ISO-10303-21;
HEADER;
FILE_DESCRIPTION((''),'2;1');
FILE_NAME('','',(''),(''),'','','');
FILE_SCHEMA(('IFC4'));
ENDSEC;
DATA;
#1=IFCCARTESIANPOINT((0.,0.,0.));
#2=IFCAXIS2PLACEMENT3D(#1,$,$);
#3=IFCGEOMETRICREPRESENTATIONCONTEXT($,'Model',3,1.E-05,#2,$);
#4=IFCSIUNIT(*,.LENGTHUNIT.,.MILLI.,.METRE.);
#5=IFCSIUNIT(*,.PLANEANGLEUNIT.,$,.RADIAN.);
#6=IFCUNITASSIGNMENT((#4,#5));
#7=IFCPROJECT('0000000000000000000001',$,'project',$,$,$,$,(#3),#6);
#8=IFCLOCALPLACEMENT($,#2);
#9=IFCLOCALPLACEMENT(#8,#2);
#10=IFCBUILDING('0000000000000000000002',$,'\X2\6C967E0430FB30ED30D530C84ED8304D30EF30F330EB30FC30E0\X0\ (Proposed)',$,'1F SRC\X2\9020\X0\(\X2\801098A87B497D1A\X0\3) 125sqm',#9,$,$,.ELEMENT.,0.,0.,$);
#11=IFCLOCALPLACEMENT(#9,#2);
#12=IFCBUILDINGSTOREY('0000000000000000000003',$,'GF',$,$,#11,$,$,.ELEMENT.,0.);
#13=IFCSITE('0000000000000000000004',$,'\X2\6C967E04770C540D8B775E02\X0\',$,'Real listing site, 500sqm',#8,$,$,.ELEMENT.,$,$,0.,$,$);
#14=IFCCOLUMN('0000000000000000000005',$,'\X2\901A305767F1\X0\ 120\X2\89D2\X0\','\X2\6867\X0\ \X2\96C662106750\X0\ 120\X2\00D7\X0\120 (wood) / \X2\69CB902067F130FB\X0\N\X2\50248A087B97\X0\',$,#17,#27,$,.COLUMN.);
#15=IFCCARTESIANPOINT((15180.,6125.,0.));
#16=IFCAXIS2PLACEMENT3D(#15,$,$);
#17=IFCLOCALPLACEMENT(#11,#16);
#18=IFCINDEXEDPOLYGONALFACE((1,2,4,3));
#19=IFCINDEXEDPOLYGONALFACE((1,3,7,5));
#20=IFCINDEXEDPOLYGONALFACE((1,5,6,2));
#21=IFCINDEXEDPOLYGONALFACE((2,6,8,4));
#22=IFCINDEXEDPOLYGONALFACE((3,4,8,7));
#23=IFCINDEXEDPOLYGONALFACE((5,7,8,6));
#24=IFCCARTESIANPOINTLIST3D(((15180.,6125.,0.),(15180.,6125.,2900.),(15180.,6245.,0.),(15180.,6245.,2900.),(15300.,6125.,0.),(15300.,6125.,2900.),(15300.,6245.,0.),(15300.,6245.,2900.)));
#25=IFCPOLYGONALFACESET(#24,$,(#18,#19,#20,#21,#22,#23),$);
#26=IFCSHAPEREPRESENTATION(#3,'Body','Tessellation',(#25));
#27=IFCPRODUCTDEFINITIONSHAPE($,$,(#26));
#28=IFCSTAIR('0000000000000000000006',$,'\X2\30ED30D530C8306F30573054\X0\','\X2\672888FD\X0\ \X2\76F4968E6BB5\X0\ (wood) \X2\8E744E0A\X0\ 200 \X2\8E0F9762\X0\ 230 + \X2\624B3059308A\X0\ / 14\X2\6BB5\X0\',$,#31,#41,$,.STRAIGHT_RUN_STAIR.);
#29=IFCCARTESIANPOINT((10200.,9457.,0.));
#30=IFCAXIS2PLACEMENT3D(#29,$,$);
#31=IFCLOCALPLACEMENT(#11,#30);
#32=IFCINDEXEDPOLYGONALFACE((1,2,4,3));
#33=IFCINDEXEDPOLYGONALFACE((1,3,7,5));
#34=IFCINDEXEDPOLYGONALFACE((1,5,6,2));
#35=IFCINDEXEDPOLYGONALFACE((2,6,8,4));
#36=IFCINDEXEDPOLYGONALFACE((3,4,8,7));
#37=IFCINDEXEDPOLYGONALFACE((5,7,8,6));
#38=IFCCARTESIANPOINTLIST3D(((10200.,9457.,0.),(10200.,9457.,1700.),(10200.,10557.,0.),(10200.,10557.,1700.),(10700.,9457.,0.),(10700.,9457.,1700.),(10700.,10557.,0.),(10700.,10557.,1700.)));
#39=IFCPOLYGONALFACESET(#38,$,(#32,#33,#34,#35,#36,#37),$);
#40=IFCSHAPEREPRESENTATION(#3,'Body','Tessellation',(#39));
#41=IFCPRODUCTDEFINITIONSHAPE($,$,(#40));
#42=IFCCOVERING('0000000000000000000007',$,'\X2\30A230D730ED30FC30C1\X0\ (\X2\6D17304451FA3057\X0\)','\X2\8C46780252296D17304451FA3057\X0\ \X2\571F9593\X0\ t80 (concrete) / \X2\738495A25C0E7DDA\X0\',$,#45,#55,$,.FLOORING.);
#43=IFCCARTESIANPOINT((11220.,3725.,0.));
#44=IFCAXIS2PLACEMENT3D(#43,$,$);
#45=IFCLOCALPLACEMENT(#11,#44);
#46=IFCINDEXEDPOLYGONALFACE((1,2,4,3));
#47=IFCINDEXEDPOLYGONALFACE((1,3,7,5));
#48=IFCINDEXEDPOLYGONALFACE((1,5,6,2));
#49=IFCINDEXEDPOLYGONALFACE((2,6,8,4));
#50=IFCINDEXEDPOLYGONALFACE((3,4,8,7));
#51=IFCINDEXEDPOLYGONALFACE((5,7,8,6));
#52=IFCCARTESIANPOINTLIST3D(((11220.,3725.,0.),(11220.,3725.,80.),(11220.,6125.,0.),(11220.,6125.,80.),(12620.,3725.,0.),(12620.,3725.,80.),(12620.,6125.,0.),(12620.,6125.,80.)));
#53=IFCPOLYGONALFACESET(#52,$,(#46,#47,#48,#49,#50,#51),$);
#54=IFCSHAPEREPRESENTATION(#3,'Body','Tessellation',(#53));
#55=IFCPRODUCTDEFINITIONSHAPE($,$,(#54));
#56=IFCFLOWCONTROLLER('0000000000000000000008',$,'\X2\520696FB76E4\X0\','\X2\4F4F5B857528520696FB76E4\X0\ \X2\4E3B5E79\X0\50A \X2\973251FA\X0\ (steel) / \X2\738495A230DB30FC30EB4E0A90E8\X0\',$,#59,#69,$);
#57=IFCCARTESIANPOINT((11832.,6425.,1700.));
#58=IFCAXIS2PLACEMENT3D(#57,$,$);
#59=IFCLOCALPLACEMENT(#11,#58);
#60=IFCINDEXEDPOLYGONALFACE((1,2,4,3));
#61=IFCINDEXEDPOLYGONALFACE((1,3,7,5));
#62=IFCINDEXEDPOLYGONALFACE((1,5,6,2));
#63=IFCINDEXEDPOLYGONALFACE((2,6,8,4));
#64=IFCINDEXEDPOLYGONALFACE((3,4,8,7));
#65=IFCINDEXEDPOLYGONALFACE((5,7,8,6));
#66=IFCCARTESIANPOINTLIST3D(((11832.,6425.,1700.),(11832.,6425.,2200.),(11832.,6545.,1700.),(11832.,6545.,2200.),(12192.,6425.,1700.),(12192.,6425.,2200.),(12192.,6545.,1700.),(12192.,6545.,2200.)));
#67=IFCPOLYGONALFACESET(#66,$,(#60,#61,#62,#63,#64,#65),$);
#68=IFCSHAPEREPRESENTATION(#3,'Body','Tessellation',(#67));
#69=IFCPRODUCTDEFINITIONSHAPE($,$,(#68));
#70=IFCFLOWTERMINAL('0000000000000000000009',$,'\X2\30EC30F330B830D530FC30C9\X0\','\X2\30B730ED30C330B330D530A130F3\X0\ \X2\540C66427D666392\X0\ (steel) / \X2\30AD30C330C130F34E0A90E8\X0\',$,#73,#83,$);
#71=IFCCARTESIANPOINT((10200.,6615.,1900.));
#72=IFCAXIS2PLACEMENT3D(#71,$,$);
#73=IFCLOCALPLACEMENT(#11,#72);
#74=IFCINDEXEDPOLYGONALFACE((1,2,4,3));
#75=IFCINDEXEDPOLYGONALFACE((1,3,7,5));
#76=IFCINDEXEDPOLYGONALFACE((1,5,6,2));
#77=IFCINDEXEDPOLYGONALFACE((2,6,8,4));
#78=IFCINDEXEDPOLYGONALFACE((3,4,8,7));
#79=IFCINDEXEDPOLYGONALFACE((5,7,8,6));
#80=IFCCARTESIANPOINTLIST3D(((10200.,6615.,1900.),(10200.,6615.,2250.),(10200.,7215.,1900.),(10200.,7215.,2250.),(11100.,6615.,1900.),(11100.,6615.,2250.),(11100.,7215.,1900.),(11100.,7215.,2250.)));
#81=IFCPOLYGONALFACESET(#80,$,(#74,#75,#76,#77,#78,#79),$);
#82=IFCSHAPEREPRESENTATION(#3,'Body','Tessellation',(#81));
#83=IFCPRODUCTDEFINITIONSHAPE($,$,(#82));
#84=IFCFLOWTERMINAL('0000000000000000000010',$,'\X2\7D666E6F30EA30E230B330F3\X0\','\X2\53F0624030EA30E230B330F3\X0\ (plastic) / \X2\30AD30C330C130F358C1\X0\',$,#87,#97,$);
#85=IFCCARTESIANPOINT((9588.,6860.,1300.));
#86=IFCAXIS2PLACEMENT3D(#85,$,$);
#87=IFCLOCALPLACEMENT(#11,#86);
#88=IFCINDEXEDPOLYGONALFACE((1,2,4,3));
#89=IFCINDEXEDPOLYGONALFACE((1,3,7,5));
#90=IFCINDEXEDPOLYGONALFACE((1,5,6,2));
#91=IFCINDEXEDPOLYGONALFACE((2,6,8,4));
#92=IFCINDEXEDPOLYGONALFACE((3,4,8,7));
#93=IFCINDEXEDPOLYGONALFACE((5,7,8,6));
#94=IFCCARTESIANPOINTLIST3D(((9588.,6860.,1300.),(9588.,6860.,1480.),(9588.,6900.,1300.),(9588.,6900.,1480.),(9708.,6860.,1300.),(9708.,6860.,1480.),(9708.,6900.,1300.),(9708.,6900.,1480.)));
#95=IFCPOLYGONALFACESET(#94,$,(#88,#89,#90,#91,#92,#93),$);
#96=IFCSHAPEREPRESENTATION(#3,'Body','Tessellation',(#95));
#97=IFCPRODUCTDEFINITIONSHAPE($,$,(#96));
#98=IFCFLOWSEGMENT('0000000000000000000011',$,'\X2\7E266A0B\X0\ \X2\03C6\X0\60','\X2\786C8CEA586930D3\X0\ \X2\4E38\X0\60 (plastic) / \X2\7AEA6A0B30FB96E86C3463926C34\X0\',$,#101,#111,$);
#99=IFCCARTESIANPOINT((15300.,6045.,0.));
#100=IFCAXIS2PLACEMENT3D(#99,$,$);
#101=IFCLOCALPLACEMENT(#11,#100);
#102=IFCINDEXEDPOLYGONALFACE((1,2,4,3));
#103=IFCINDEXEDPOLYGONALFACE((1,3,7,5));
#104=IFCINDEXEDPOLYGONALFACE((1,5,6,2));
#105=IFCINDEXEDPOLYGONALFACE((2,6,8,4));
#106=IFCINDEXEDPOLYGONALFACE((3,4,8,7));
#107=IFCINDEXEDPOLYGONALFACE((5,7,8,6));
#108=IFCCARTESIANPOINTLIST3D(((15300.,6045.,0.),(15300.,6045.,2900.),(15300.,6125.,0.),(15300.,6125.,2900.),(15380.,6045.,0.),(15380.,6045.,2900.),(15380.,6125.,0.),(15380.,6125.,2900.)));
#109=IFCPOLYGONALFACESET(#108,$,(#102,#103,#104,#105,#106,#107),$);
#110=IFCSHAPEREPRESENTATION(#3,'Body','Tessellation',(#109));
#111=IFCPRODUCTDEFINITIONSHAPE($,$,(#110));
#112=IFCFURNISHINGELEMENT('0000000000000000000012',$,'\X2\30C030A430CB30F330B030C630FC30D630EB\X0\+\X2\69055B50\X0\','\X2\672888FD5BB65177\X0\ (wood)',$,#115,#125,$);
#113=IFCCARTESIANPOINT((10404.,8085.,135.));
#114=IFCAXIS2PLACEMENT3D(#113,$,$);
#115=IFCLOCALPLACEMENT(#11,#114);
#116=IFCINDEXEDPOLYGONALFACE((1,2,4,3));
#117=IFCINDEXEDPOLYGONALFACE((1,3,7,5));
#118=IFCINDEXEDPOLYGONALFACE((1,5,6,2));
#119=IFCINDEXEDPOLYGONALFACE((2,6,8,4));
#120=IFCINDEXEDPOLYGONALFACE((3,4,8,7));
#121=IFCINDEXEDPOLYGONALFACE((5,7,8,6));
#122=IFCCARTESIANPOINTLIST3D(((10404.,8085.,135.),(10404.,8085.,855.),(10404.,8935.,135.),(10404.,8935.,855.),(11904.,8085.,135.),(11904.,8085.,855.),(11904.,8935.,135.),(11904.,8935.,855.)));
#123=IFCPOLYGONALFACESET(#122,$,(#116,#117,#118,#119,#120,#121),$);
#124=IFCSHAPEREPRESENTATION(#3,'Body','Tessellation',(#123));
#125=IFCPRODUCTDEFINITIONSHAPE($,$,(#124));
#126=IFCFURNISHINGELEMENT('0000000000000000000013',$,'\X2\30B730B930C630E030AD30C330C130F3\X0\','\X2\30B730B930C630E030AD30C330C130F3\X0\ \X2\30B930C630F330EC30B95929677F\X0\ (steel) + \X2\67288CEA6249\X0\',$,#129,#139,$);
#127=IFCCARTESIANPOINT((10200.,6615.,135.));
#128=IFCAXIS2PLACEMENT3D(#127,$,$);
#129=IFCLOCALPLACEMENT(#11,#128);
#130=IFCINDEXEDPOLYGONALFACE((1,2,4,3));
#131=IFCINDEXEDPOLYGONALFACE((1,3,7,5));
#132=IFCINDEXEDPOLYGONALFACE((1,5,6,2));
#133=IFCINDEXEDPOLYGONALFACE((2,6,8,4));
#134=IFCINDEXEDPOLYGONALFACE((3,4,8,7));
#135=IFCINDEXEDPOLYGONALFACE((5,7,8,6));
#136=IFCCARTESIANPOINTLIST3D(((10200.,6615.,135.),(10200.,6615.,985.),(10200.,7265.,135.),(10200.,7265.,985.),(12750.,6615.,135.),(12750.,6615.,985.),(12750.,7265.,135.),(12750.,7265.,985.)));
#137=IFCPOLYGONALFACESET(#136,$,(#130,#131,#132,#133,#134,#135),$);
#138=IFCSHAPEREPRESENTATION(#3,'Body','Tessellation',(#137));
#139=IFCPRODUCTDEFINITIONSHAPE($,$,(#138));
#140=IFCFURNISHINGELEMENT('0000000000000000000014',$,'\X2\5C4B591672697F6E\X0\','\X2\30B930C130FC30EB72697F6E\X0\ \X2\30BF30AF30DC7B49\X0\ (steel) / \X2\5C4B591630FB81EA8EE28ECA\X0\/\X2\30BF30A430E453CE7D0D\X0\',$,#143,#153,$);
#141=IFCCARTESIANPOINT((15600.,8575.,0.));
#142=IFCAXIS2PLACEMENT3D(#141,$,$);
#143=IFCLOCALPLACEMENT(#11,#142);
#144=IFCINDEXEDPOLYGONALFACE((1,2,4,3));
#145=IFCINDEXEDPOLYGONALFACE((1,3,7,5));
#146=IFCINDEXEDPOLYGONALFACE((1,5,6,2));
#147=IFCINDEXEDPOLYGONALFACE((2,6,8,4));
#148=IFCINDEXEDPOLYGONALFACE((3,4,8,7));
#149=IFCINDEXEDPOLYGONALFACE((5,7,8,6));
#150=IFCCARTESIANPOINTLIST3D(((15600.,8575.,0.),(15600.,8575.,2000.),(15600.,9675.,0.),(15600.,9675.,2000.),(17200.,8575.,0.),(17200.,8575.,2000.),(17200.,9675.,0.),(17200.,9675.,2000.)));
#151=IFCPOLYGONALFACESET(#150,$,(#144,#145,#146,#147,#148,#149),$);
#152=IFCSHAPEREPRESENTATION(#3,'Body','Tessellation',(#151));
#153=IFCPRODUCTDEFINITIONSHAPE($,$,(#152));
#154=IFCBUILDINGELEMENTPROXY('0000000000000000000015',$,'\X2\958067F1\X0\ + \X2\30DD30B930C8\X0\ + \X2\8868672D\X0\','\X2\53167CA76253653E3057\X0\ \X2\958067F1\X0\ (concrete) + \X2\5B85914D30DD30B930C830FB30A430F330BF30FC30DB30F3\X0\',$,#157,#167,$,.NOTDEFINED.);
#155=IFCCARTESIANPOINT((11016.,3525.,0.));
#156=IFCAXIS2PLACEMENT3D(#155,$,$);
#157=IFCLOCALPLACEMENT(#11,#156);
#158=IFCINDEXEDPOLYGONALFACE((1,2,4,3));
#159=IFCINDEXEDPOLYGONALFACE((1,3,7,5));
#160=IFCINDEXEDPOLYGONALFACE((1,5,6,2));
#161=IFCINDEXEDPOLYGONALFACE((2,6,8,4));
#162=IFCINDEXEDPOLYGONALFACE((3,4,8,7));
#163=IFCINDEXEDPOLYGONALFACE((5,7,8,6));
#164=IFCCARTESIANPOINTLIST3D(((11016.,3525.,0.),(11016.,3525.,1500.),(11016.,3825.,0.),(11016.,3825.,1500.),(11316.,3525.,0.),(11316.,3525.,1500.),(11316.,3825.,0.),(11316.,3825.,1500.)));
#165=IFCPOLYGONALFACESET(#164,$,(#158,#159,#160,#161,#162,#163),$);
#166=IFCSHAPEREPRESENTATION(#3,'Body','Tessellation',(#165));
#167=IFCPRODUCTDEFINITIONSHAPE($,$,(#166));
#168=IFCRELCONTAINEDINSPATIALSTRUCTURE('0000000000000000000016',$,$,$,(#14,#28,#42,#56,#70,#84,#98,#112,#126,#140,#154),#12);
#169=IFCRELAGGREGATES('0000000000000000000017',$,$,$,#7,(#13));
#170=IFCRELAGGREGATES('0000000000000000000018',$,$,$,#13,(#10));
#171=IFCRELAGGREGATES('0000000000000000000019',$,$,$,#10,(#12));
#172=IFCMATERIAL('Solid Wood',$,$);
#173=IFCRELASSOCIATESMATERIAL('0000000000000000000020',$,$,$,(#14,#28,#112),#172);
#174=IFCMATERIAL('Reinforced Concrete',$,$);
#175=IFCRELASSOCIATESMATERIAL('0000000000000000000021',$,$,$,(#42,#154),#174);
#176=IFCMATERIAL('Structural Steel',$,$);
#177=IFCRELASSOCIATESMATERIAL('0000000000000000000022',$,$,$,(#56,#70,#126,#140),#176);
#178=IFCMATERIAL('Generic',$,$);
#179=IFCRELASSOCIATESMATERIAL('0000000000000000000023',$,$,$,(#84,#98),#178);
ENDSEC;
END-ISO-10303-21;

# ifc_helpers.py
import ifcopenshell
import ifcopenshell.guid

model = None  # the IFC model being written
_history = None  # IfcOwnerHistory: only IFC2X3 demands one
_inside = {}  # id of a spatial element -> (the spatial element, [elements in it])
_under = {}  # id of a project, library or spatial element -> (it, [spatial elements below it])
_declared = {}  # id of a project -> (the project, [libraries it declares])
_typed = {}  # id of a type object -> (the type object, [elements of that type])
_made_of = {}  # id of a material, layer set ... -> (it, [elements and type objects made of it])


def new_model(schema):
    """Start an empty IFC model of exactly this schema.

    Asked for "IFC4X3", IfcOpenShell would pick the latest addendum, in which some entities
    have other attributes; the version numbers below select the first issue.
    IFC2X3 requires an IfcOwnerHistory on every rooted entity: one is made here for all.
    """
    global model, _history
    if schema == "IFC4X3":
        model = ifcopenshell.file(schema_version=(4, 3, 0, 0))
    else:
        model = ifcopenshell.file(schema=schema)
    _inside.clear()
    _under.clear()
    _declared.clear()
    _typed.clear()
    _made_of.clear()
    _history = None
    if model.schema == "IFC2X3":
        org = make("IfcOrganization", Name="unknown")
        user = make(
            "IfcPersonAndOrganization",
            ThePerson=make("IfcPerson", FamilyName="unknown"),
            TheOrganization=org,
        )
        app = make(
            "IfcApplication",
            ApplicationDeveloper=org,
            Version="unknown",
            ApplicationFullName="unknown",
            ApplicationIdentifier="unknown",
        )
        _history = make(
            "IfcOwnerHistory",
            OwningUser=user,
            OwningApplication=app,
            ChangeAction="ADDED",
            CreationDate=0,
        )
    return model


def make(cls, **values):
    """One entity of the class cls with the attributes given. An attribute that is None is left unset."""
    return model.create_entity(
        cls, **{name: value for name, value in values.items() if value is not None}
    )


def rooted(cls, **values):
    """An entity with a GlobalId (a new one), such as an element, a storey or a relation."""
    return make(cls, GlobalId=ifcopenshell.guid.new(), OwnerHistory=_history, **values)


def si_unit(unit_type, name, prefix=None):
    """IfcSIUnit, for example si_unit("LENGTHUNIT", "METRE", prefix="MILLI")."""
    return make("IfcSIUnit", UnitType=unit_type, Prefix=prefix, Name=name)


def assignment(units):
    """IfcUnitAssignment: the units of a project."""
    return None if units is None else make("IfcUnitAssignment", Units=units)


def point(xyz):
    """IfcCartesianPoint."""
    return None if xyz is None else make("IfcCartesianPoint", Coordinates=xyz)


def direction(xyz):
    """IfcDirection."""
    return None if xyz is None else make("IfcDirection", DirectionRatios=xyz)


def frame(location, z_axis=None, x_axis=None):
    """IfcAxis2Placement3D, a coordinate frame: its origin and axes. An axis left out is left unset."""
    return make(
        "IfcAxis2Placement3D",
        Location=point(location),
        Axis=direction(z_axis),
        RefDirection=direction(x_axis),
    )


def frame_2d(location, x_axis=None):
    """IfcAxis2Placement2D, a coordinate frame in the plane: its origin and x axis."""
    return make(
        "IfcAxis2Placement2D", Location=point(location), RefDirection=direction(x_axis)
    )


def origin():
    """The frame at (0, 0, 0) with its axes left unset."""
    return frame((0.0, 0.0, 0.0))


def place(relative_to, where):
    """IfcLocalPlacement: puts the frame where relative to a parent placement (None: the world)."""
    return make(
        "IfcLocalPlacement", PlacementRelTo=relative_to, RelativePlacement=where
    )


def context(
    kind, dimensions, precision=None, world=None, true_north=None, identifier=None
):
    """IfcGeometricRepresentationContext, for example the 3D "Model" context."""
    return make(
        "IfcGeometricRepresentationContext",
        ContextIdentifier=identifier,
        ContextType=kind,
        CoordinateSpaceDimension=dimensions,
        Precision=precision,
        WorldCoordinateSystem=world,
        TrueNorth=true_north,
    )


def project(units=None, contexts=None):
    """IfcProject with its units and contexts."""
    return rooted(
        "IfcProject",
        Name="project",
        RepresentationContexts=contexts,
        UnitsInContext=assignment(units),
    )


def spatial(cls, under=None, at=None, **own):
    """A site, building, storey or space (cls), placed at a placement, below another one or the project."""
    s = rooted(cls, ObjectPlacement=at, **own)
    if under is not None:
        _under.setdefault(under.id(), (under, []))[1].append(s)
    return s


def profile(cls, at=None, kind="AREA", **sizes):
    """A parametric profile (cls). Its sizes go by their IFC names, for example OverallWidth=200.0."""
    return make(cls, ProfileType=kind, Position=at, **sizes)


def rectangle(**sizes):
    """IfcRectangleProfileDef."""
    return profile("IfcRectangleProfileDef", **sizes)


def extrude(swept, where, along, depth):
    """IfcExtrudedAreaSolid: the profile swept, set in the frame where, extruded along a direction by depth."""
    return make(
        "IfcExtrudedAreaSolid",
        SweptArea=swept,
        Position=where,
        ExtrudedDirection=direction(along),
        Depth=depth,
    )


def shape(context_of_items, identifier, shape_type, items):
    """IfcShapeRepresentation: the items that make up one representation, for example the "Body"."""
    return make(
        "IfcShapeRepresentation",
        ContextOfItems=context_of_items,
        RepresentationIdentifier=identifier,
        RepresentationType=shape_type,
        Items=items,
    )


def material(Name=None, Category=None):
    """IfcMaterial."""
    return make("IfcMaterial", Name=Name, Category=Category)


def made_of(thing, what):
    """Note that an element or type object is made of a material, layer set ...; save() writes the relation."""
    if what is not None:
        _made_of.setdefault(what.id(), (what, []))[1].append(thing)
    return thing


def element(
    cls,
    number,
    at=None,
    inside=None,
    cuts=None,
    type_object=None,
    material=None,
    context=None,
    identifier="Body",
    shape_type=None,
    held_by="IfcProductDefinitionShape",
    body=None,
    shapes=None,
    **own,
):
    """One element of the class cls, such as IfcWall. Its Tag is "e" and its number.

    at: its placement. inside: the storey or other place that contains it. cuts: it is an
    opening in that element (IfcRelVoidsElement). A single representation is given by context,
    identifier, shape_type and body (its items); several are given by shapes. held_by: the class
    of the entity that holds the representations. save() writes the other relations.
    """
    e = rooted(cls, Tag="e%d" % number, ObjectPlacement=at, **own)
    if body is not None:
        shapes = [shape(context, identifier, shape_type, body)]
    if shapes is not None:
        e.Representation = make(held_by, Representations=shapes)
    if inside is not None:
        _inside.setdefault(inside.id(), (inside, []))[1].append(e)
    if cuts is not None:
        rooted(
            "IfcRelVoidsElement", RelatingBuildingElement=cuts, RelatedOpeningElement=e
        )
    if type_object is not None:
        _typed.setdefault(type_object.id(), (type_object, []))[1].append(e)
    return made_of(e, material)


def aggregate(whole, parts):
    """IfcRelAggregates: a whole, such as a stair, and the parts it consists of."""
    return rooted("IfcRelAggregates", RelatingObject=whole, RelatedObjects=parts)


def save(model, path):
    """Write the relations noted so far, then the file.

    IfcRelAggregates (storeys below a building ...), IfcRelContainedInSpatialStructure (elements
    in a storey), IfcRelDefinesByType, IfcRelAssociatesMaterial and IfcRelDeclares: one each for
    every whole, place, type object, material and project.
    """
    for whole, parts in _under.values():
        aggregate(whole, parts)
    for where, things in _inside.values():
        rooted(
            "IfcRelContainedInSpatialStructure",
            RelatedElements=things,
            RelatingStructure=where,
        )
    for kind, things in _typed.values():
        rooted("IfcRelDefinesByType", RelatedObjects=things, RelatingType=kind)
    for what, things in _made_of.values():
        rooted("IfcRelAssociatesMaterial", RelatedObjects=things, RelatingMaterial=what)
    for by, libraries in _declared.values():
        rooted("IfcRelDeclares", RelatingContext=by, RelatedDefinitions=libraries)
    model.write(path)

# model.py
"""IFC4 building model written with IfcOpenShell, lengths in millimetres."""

from ifc_helpers import new_model, si_unit, frame, frame_2d, origin, place, context, project, spatial, rectangle, extrude, material, element, save


model = new_model("IFC4")

# Units and contexts
model_context = context("Model", 3, precision=1e-05, world=origin())
ifc_project = project(units=[si_unit("LENGTHUNIT", "METRE", prefix="MILLI"), si_unit("PLANEANGLEUNIT", "RADIAN")], contexts=[model_context])

# Site, building, storey
site_placement = place(None, origin())
site = spatial("IfcSite", under=ifc_project, at=site_placement, Name="沖縄県名護市", ObjectType="Real listing site, 500sqm", CompositionType="ELEMENT", RefElevation=0.0)
building_placement = place(site_placement, origin())
building = spatial("IfcBuilding", under=site, at=building_placement, Name="沖縄・ロフト付きワンルーム (Proposed)", ObjectType="1F SRC造(耐風等級3) 125sqm", CompositionType="ELEMENT", ElevationOfRefHeight=0.0, ElevationOfTerrain=0.0)
storey_placement = place(building_placement, origin())
storey = spatial("IfcBuildingStorey", under=building, at=storey_placement, Name="GF", CompositionType="ELEMENT", Elevation=0.0)

# Column
ifc_material_1 = material(Name="Solid Wood")
column_1_placement = place(storey_placement, frame((15180.0, 6125.0, 0.0)))
element("IfcColumn", 1, at=column_1_placement, inside=storey, material=ifc_material_1, Name="通し柱 120角", Description="桧 集成材 120×120 (wood) / 構造柱・N値計算", PredefinedType="COLUMN", context=model_context, shape_type="SweptSolid", body=[
    extrude(rectangle(XDim=120.0, YDim=120.0, at=frame_2d((60.0, 60.0))), frame((15180.0, 6125.0, 0.0)), (0.0, 0.0, 1.0), 2900.0),
])

# Stair
stair_placement = place(storey_placement, frame((10200.0, 9457.0, 0.0)))
element("IfcStair", 2, at=stair_placement, inside=storey, material=ifc_material_1, Name="ロフトはしご", Description="木製 直階段 (wood) 蹴上 200 踏面 230 + 手すり / 14段", PredefinedType="STRAIGHT_RUN_STAIR", context=model_context, shape_type="SweptSolid", body=[
    extrude(rectangle(XDim=500.0, YDim=1100.0, at=frame_2d((250.0, 550.0))), frame((10200.0, 9457.0, 0.0)), (0.0, 0.0, 1.0), 1700.0),
])

# Covering
ifc_material_2 = material(Name="Reinforced Concrete")
covering_placement = place(storey_placement, frame((11220.0, 3725.0, 0.0)))
element("IfcCovering", 3, at=covering_placement, inside=storey, material=ifc_material_2, Name="アプローチ (洗い出し)", Description="豆砂利洗い出し 土間 t80 (concrete) / 玄関導線", PredefinedType="FLOORING", context=model_context, shape_type="SweptSolid", body=[
    extrude(rectangle(XDim=1400.0, YDim=2400.0, at=frame_2d((700.0, 1200.0))), frame((11220.0, 3725.0, 0.0)), (0.0, 0.0, 1.0), 80.0),
])

# Flow controller
ifc_material_3 = material(Name="Structural Steel")
flow_controller_placement = place(storey_placement, frame((11832.0, 6425.0, 1700.0)))
element("IfcFlowController", 4, at=flow_controller_placement, inside=storey, material=ifc_material_3, Name="分電盤", Description="住宅用分電盤 主幹50A 露出 (steel) / 玄関ホール上部", context=model_context, shape_type="SweptSolid", body=[
    extrude(rectangle(XDim=360.0, YDim=120.0, at=frame_2d((180.0, 60.0))), frame((11832.0, 6425.0, 1700.0)), (0.0, 0.0, 1.0), 500.0),
])

# Flow terminals
flow_terminal_1_placement = place(storey_placement, frame((10200.0, 6615.0, 1900.0)))
element("IfcFlowTerminal", 5, at=flow_terminal_1_placement, inside=storey, material=ifc_material_3, Name="レンジフード", Description="シロッコファン 同時給排 (steel) / キッチン上部", context=model_context, shape_type="SweptSolid", body=[
    extrude(rectangle(XDim=900.0, YDim=600.0, at=frame_2d((450.0, 300.0))), frame((10200.0, 6615.0, 1900.0)), (0.0, 0.0, 1.0), 350.0),
])
ifc_material_4 = material(Name="Generic")
flow_terminal_2_placement = place(storey_placement, frame((9588.0, 6860.0, 1300.0)))
element("IfcFlowTerminal", 6, at=flow_terminal_2_placement, inside=storey, material=ifc_material_4, Name="給湯リモコン", Description="台所リモコン (plastic) / キッチン壁", context=model_context, shape_type="SweptSolid", body=[
    extrude(rectangle(XDim=120.0, YDim=40.0, at=frame_2d((60.0, 20.0))), frame((9588.0, 6860.0, 1300.0)), (0.0, 0.0, 1.0), 180.0),
])

# Flow segment
flow_segment_placement = place(storey_placement, frame((15300.0, 6045.0, 0.0)))
element("IfcFlowSegment", 7, at=flow_segment_placement, inside=storey, material=ifc_material_4, Name="縦樋 φ60", Description="硬質塩ビ 丸60 (plastic) / 竪樋・雨水排水", context=model_context, shape_type="SweptSolid", body=[
    extrude(rectangle(XDim=80.0, YDim=80.0, at=frame_2d((40.0, 40.0))), frame((15300.0, 6045.0, 0.0)), (0.0, 0.0, 1.0), 2900.0),
])

# Furnishing elements
furnishing_1_placement = place(storey_placement, frame((10404.0, 8085.0, 135.0)))
element("IfcFurnishingElement", 8, at=furnishing_1_placement, inside=storey, material=ifc_material_1, Name="ダイニングテーブル+椅子", Description="木製家具 (wood)", context=model_context, shape_type="SweptSolid", body=[
    extrude(rectangle(XDim=1500.0, YDim=850.0, at=frame_2d((750.0, 425.0))), frame((10404.0, 8085.0, 135.0)), (0.0, 0.0, 1.0), 720.0),
])
furnishing_2_placement = place(storey_placement, frame((10200.0, 6615.0, 135.0)))
element("IfcFurnishingElement", 9, at=furnishing_2_placement, inside=storey, material=ifc_material_3, Name="システムキッチン", Description="システムキッチン ステンレス天板 (steel) + 木質扉", context=model_context, shape_type="SweptSolid", body=[
    extrude(rectangle(XDim=2550.0, YDim=650.0, at=frame_2d((1275.0, 325.0))), frame((10200.0, 6615.0, 135.0)), (0.0, 0.0, 1.0), 850.0),
])
furnishing_3_placement = place(storey_placement, frame((15600.0, 8575.0, 0.0)))
element("IfcFurnishingElement", 10, at=furnishing_3_placement, inside=storey, material=ifc_material_3, Name="屋外物置", Description="スチール物置 タクボ等 (steel) / 屋外・自転車/タイヤ収納", context=model_context, shape_type="SweptSolid", body=[
    extrude(rectangle(XDim=1600.0, YDim=1100.0, at=frame_2d((800.0, 550.0))), frame((15600.0, 8575.0, 0.0)), (0.0, 0.0, 1.0), 2000.0),
])

# Building element proxy
proxy_placement = place(storey_placement, frame((11016.0, 3525.0, 0.0)))
element("IfcBuildingElementProxy", 11, at=proxy_placement, inside=storey, material=ifc_material_2, Name="門柱 + ポスト + 表札", Description="化粧打放し 門柱 (concrete) + 宅配ポスト・インターホン", PredefinedType="NOTDEFINED", context=model_context, shape_type="SweptSolid", body=[
    extrude(rectangle(XDim=300.0, YDim=300.0, at=frame_2d((150.0, 150.0))), frame((11016.0, 3525.0, 0.0)), (0.0, 0.0, 1.0), 1500.0),
])

save(model, "model.ifc")
